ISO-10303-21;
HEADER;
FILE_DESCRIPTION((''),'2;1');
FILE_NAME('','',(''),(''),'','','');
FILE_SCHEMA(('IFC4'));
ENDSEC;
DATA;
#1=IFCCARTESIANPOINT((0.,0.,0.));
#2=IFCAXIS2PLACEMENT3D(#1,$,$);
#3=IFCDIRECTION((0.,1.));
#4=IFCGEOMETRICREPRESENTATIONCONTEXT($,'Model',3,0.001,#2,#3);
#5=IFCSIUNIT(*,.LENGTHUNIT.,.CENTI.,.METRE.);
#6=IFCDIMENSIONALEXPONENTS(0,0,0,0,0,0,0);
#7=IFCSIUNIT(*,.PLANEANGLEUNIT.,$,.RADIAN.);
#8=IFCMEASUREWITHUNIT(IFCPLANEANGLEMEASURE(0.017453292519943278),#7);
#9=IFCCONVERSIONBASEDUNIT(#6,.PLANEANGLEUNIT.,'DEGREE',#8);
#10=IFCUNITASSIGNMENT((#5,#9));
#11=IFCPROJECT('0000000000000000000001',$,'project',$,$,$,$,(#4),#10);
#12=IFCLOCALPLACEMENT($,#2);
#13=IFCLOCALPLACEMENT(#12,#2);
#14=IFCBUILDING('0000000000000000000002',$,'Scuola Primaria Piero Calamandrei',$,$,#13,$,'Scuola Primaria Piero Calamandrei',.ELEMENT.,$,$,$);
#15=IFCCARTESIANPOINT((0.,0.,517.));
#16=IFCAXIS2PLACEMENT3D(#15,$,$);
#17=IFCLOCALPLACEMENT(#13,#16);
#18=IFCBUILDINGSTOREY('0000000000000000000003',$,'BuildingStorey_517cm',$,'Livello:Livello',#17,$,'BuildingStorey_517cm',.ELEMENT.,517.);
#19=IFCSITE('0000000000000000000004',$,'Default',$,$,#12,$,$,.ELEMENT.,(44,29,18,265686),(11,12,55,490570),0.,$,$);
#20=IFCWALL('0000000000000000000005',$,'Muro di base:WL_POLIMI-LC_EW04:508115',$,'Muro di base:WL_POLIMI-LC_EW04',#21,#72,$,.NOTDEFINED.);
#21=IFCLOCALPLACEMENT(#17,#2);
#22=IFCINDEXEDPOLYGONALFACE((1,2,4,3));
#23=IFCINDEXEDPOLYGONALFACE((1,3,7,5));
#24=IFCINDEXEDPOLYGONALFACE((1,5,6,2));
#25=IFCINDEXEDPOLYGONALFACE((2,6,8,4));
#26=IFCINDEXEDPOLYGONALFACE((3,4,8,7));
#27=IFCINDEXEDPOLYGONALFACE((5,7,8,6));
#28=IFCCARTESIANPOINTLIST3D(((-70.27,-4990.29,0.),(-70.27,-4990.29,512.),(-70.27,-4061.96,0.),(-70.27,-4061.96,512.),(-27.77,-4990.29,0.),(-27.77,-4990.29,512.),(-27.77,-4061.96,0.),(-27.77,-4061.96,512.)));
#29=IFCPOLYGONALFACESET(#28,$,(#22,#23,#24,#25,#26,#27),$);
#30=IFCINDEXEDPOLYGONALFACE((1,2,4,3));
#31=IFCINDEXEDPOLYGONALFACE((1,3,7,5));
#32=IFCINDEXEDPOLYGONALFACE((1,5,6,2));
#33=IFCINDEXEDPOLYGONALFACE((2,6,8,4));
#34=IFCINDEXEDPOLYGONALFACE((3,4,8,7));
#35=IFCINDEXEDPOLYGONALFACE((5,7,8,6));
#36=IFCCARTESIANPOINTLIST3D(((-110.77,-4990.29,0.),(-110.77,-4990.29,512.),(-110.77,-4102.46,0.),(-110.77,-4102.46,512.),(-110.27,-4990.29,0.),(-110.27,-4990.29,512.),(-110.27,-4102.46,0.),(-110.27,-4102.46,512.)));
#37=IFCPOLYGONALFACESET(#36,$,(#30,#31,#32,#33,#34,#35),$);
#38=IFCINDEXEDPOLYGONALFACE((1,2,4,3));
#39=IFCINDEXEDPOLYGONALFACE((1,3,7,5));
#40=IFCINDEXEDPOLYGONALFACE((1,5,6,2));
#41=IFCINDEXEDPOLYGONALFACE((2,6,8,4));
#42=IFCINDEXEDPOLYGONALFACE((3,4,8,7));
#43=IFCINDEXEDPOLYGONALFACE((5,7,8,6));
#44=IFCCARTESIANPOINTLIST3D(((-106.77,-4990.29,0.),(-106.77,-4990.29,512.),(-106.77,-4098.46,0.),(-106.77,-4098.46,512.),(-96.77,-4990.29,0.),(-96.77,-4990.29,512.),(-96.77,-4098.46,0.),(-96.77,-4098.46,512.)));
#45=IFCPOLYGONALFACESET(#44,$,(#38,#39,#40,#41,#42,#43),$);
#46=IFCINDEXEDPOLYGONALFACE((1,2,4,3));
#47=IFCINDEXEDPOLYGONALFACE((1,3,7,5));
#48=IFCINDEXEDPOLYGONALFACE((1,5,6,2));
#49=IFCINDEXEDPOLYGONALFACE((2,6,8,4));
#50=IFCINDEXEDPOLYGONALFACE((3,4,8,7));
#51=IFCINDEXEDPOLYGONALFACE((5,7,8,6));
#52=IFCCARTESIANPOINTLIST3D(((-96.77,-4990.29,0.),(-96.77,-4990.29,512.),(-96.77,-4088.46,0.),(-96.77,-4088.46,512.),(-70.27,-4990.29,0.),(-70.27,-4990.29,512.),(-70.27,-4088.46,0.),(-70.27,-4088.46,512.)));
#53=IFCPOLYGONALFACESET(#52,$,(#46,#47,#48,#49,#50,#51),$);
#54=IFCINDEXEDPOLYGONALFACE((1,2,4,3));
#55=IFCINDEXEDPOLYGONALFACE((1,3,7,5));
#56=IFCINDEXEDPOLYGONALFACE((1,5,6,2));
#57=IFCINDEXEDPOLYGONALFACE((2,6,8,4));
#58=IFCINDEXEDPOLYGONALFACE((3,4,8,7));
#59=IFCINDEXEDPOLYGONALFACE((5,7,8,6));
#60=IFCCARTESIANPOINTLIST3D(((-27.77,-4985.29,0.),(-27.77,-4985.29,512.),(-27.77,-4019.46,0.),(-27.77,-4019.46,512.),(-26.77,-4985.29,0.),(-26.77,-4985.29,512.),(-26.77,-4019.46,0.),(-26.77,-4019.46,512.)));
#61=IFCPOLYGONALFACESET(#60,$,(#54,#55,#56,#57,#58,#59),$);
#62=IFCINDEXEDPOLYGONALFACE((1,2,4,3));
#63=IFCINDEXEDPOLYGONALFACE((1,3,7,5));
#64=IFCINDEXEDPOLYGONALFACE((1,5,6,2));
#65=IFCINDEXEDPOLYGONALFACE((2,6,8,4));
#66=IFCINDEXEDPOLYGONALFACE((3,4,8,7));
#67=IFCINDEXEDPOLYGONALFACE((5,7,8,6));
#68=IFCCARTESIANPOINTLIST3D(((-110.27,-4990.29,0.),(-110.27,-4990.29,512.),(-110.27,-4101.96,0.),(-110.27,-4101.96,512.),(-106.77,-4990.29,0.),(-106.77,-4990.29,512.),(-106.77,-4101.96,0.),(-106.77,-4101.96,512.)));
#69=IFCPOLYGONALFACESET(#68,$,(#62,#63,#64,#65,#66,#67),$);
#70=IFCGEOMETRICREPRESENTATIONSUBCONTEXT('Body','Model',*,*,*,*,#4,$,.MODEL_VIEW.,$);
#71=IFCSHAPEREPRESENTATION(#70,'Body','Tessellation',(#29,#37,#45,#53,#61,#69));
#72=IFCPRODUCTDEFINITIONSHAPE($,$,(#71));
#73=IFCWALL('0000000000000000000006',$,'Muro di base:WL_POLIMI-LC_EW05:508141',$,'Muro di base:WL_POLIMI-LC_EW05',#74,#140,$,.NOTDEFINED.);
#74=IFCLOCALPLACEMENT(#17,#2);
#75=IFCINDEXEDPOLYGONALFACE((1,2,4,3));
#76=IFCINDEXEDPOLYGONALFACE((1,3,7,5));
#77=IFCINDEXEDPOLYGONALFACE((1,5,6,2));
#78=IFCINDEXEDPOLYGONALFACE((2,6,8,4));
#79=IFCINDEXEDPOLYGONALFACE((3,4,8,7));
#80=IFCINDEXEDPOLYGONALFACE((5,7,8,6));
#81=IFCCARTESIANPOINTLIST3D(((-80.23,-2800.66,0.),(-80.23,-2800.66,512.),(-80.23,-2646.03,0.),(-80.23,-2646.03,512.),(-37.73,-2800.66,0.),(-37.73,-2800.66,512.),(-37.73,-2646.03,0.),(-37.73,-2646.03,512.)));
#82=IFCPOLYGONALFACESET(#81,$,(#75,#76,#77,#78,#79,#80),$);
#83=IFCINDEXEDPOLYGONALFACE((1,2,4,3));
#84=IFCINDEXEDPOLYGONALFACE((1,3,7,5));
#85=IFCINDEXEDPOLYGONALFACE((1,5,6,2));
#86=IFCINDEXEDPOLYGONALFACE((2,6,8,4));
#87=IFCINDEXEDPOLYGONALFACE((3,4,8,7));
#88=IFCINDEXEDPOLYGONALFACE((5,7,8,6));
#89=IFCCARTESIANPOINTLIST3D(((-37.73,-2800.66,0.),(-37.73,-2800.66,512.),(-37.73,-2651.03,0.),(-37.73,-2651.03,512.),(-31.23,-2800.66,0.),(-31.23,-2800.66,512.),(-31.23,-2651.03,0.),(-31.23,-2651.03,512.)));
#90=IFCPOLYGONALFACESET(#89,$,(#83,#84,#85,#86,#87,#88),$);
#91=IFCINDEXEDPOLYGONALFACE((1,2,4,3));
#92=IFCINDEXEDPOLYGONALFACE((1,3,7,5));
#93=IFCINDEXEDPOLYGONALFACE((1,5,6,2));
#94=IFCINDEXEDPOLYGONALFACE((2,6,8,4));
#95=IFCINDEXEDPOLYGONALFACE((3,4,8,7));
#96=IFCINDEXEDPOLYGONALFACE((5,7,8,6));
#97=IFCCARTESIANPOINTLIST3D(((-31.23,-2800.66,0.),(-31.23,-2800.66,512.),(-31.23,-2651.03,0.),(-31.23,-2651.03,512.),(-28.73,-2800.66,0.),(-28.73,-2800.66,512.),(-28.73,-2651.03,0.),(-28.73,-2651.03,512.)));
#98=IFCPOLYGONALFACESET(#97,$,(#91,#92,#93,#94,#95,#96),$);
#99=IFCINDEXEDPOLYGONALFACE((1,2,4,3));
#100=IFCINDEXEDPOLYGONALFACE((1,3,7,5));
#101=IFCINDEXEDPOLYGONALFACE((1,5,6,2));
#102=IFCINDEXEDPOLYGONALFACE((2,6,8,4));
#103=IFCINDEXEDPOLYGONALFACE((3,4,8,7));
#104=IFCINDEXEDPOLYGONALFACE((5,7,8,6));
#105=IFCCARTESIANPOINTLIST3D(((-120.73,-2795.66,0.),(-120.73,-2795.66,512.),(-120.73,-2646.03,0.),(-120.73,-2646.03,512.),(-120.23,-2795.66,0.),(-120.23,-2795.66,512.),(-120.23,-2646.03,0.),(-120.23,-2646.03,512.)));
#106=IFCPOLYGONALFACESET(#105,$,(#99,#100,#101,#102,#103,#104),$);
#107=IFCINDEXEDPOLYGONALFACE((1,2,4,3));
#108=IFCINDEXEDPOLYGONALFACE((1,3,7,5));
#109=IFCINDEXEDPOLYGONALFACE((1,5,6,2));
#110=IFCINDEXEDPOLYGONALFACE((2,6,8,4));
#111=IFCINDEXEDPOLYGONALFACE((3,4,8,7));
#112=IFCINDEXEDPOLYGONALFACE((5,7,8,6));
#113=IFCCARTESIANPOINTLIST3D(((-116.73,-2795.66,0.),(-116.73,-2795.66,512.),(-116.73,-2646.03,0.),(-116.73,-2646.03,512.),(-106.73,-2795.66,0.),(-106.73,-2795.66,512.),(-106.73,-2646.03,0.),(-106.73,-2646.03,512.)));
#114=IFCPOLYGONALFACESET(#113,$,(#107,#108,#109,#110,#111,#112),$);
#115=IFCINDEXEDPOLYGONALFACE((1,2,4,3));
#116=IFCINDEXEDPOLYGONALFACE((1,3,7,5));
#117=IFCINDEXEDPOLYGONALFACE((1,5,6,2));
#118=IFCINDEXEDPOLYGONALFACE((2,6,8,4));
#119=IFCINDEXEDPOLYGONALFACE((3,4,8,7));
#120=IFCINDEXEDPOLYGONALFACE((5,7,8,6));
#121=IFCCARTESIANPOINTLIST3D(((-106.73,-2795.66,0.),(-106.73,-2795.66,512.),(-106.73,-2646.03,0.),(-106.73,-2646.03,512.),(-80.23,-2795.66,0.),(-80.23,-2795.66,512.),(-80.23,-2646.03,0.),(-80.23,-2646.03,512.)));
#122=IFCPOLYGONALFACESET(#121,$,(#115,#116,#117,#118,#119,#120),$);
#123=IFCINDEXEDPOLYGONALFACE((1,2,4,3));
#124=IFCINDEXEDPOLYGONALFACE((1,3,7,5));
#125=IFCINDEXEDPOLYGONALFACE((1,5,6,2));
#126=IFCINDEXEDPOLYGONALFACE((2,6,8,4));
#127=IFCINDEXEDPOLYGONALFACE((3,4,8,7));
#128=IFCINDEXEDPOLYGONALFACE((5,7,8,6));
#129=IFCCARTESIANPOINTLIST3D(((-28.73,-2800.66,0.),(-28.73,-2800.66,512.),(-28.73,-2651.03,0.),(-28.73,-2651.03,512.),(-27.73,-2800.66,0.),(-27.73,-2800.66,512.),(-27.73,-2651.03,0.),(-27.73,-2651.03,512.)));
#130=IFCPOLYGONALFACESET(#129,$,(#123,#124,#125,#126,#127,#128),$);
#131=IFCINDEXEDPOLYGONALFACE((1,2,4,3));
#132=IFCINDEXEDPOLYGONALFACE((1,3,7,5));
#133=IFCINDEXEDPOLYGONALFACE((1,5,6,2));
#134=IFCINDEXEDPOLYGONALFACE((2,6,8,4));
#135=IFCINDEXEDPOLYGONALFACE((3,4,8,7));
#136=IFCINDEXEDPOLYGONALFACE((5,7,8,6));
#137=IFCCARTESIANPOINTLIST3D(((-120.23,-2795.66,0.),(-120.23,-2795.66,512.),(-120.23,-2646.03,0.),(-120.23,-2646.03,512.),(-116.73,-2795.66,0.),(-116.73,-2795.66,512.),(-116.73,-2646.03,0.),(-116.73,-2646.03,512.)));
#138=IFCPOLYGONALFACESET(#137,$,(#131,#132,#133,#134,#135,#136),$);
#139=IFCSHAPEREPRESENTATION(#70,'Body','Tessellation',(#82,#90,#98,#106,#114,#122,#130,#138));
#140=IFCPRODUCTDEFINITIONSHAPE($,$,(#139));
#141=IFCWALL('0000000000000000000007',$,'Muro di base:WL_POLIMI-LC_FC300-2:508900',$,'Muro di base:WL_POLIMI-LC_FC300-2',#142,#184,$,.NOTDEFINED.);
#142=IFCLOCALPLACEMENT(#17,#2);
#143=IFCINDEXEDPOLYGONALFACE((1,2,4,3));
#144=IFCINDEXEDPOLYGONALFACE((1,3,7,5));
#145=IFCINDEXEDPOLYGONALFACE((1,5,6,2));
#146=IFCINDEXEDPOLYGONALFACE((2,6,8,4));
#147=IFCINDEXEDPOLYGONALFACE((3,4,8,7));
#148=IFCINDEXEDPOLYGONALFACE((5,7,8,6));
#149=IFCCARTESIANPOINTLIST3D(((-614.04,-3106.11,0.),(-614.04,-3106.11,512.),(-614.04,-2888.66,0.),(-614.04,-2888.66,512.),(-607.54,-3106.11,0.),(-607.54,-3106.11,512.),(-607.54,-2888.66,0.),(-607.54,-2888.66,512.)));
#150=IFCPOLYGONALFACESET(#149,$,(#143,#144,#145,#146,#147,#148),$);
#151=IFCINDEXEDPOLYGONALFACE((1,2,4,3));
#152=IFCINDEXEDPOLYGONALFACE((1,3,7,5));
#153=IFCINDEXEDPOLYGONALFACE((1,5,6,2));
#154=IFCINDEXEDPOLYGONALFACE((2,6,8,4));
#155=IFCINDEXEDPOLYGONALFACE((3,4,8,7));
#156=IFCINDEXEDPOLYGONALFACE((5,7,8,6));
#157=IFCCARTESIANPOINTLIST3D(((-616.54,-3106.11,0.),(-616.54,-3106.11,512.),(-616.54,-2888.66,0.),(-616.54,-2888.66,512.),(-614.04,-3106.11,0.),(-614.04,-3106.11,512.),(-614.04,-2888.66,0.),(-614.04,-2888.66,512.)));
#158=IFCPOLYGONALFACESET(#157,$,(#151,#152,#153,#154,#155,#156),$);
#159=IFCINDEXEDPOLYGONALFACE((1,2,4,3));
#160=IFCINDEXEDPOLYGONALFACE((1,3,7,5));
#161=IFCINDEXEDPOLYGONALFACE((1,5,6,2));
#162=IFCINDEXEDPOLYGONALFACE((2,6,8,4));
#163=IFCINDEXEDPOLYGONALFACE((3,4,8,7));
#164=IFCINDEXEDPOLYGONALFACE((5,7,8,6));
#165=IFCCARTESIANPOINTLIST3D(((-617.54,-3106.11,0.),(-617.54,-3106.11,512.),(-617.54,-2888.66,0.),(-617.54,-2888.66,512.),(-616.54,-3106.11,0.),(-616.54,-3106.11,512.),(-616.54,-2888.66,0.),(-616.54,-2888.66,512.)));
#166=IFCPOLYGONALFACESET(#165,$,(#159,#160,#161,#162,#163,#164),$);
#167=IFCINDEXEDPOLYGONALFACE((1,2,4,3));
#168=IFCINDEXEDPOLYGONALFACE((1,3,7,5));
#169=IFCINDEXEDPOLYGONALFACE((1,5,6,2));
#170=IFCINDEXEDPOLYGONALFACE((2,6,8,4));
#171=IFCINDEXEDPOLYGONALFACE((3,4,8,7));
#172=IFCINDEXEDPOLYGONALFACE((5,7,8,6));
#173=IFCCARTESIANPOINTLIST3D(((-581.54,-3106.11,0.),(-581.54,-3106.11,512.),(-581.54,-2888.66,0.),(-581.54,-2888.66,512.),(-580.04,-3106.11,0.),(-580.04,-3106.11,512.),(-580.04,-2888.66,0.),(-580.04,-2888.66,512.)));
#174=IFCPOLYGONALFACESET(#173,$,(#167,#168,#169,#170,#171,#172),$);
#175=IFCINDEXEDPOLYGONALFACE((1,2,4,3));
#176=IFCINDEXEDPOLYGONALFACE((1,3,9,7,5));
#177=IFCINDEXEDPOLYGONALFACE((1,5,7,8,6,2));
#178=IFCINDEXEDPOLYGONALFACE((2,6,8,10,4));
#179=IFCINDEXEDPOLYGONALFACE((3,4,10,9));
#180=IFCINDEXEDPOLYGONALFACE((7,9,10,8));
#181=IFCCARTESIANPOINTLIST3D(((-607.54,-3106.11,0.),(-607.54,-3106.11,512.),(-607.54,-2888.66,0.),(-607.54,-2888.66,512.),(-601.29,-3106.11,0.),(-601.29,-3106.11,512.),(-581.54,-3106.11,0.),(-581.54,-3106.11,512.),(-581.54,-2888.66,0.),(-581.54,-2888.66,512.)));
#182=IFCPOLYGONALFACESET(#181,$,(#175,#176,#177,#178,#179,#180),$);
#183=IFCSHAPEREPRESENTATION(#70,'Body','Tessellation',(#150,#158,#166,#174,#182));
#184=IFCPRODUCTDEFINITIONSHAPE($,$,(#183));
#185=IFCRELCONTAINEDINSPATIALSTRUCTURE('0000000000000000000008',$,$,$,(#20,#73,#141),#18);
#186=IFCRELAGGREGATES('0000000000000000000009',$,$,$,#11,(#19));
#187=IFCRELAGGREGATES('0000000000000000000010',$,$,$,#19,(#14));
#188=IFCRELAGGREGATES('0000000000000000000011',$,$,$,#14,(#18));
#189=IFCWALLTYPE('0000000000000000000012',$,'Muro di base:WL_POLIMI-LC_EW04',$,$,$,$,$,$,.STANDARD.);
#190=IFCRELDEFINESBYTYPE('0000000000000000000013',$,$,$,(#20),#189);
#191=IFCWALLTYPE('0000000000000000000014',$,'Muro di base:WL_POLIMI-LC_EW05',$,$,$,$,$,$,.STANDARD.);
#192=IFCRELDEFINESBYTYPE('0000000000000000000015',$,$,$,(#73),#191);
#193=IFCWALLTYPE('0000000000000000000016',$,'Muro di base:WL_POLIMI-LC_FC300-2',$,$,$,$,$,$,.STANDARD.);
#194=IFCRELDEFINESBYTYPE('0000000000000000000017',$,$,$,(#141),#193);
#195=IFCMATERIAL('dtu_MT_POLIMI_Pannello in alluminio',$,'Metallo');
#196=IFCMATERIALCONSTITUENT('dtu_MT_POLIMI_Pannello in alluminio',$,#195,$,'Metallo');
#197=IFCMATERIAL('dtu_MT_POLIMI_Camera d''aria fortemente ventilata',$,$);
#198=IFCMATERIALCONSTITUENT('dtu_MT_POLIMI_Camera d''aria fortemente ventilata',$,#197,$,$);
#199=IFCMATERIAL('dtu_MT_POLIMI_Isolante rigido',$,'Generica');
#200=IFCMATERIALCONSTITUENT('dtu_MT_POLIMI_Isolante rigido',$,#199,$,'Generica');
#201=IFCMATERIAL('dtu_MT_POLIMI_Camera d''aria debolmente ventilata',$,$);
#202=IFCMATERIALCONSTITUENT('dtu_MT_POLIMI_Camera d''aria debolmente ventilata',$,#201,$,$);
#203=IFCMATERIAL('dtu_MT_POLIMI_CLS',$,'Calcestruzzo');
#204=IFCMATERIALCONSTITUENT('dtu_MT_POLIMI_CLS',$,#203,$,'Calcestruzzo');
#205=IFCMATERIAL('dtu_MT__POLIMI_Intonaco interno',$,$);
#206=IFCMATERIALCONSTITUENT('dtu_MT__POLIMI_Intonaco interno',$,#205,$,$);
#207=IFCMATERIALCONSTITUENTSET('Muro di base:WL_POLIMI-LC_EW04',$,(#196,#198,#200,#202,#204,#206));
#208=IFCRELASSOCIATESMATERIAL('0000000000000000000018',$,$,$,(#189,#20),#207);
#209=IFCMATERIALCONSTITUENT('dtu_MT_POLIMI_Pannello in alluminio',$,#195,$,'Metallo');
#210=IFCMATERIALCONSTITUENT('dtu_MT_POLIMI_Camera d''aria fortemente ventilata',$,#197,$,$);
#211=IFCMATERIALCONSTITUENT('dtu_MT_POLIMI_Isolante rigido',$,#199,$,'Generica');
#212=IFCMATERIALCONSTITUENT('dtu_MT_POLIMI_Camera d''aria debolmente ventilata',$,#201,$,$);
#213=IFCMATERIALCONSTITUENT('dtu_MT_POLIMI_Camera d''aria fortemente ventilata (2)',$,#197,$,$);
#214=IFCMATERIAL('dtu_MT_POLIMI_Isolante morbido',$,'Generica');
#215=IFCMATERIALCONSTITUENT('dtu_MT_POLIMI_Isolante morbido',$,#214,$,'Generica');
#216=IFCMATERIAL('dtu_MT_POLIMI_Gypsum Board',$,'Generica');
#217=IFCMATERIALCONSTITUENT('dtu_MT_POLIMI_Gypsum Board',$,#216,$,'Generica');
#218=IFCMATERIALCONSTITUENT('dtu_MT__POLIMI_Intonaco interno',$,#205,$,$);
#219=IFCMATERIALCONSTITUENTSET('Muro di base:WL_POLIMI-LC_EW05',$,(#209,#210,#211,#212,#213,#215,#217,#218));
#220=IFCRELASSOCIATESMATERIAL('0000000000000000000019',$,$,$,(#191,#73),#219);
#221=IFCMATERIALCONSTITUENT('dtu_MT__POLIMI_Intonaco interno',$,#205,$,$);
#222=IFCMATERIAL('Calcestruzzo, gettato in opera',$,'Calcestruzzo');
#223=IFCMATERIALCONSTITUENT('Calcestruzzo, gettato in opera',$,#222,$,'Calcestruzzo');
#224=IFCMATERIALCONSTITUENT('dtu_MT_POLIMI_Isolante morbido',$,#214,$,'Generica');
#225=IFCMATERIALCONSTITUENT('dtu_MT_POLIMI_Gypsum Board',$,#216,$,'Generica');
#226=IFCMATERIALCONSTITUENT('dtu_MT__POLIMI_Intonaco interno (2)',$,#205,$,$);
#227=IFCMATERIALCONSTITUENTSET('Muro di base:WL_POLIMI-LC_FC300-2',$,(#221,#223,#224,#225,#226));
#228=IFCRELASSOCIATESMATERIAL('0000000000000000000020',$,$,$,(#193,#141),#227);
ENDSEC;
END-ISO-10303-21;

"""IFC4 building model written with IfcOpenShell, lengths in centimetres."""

from ifc_helpers import new_model, entity, si_unit, converted_unit, direction, frame, origin, place, context, subcontext, project, spatial, indexed_curve, outline, extrude, material, constituent, constituent_set, type_object, element, save


model = new_model("IFC4")

# Units and contexts
model_context = context("Model", 3, precision=0.001, world=origin(), true_north=direction((0.0, 1.0)))
body_context = subcontext(model_context, "Body", "Model", "MODEL_VIEW")
ifc_project = project(units=[si_unit("LENGTHUNIT", "METRE", prefix="CENTI"), converted_unit("PLANEANGLEUNIT", "DEGREE", entity("IfcPlaneAngleMeasure", 0.017453292519943278), si_unit("PLANEANGLEUNIT", "RADIAN"), dimensions=[0, 0, 0, 0, 0, 0, 0])], contexts=[model_context])

# Site, building, storey
site_placement = place(None, origin())
site = spatial("IfcSite", under=ifc_project, at=site_placement, Name="Default", CompositionType="ELEMENT", RefLatitude=(44, 29, 18, 265686), RefLongitude=(11, 12, 55, 490570), RefElevation=0.0)
building_placement = place(site_placement, origin())
building = spatial("IfcBuilding", under=site, at=building_placement, Name="Scuola Primaria Piero Calamandrei", LongName="Scuola Primaria Piero Calamandrei", CompositionType="ELEMENT")
storey_placement = place(building_placement, frame((0.0, 0.0, 517.0)))
storey = spatial("IfcBuildingStorey", under=building, at=storey_placement, Name="BuildingStorey_517cm", ObjectType="Livello:Livello", LongName="BuildingStorey_517cm", CompositionType="ELEMENT", Elevation=517.0)

# Walls
ifc_material_1 = material(Name="dtu_MT_POLIMI_Pannello in alluminio", Category="Metallo")
ifc_constituent_1 = constituent(ifc_material_1, Name="dtu_MT_POLIMI_Pannello in alluminio", Category="Metallo")
ifc_material_2 = material(Name="dtu_MT_POLIMI_Camera d'aria fortemente ventilata")
ifc_constituent_2 = constituent(ifc_material_2, Name="dtu_MT_POLIMI_Camera d'aria fortemente ventilata")
ifc_material_3 = material(Name="dtu_MT_POLIMI_Isolante rigido", Category="Generica")
ifc_constituent_3 = constituent(ifc_material_3, Name="dtu_MT_POLIMI_Isolante rigido", Category="Generica")
ifc_material_4 = material(Name="dtu_MT_POLIMI_Camera d'aria debolmente ventilata")
ifc_constituent_4 = constituent(ifc_material_4, Name="dtu_MT_POLIMI_Camera d'aria debolmente ventilata")
ifc_material_5 = material(Name="dtu_MT_POLIMI_CLS", Category="Calcestruzzo")
ifc_constituent_5 = constituent(ifc_material_5, Name="dtu_MT_POLIMI_CLS", Category="Calcestruzzo")
ifc_material_6 = material(Name="dtu_MT__POLIMI_Intonaco interno")
ifc_constituent_6 = constituent(ifc_material_6, Name="dtu_MT__POLIMI_Intonaco interno")
ifc_constituent_set_1 = constituent_set(constituents=[ifc_constituent_1, ifc_constituent_2, ifc_constituent_3, ifc_constituent_4, ifc_constituent_5, ifc_constituent_6], Name="Muro di base:WL_POLIMI-LC_EW04")
wall_type_1 = type_object("IfcWallType", Name="Muro di base:WL_POLIMI-LC_EW04", PredefinedType="STANDARD", material=ifc_constituent_set_1)
wall_1_placement = place(storey_placement, frame((-68.77, -4990.29, 0.0), z_axis=(0.0, 0.0, 1.0), x_axis=(0.0, 1.0, 0.0)))
element("IfcWall", 1, at=wall_1_placement, inside=storey, type_object=wall_type_1, material=ifc_constituent_set_1, Name="Muro di base:WL_POLIMI-LC_EW04:508115", ObjectType="Muro di base:WL_POLIMI-LC_EW04", PredefinedType="NOTDEFINED", context=body_context, shape_type="SweptSolid", body=[
    extrude(outline(indexed_curve([(-464.16, -21.25), (464.16, -21.25), (464.16, 21.25), (-464.16, 21.25), (-464.16, -21.25)], self_intersect=False)), frame((464.16, -19.75, 0.0)), (0.0, 0.0, 1.0), 512.0),
    extrude(outline(indexed_curve([(-0.25, -443.91), (0.25, -443.91), (0.25, 443.91), (-0.25, 443.91), (-0.25, -443.91)], self_intersect=False)), frame((443.91, 41.75, 0.0), z_axis=(0.0, 0.0, 1.0), x_axis=(0.0, -1.0, 0.0)), (0.0, 0.0, 1.0), 512.0),
    extrude(outline(indexed_curve([(-445.91, -5.0), (445.91, -5.0), (445.91, 5.0), (-445.91, 5.0), (-445.91, -5.0)], self_intersect=False)), frame((445.91, 33.0, 0.0)), (0.0, 0.0, 1.0), 512.0),
    extrude(outline(indexed_curve([(-450.91, -13.25), (450.91, -13.25), (450.91, 13.25), (-450.91, 13.25), (-450.91, -13.25)], self_intersect=False)), frame((450.91, 14.75, 0.0)), (0.0, 0.0, 1.0), 512.0),
    extrude(outline(indexed_curve([(-482.91, -0.5), (482.91, -0.5), (482.91, 0.5), (-482.91, 0.5), (-482.91, -0.5)], self_intersect=False)), frame((487.91, -41.5, 0.0)), (0.0, 0.0, 1.0), 512.0),
    extrude(outline(indexed_curve([(-444.16, -1.75), (444.16, -1.75), (444.16, 1.75), (-444.16, 1.75), (-444.16, -1.75)], self_intersect=False)), frame((444.16, 39.75, 0.0)), (0.0, 0.0, 1.0), 512.0),
])
ifc_constituent_7 = constituent(ifc_material_1, Name="dtu_MT_POLIMI_Pannello in alluminio", Category="Metallo")
ifc_constituent_8 = constituent(ifc_material_2, Name="dtu_MT_POLIMI_Camera d'aria fortemente ventilata")
ifc_constituent_9 = constituent(ifc_material_3, Name="dtu_MT_POLIMI_Isolante rigido", Category="Generica")
ifc_constituent_10 = constituent(ifc_material_4, Name="dtu_MT_POLIMI_Camera d'aria debolmente ventilata")
ifc_constituent_11 = constituent(ifc_material_2, Name="dtu_MT_POLIMI_Camera d'aria fortemente ventilata (2)")
ifc_material_7 = material(Name="dtu_MT_POLIMI_Isolante morbido", Category="Generica")
ifc_constituent_12 = constituent(ifc_material_7, Name="dtu_MT_POLIMI_Isolante morbido", Category="Generica")
ifc_material_8 = material(Name="dtu_MT_POLIMI_Gypsum Board", Category="Generica")
ifc_constituent_13 = constituent(ifc_material_8, Name="dtu_MT_POLIMI_Gypsum Board", Category="Generica")
ifc_constituent_14 = constituent(ifc_material_6, Name="dtu_MT__POLIMI_Intonaco interno")
ifc_constituent_set_2 = constituent_set(constituents=[ifc_constituent_7, ifc_constituent_8, ifc_constituent_9, ifc_constituent_10, ifc_constituent_11, ifc_constituent_12, ifc_constituent_13, ifc_constituent_14], Name="Muro di base:WL_POLIMI-LC_EW05")
wall_type_2 = type_object("IfcWallType", Name="Muro di base:WL_POLIMI-LC_EW05", PredefinedType="STANDARD", material=ifc_constituent_set_2)
wall_2_placement = place(storey_placement, frame((-74.23, -2800.66, 0.0), z_axis=(0.0, 0.0, 1.0), x_axis=(0.0, 1.0, 0.0)))
element("IfcWall", 2, at=wall_2_placement, inside=storey, type_object=wall_type_2, material=ifc_constituent_set_2, Name="Muro di base:WL_POLIMI-LC_EW05:508141", ObjectType="Muro di base:WL_POLIMI-LC_EW05", PredefinedType="NOTDEFINED", context=body_context, shape_type="SweptSolid", body=[
    extrude(outline(indexed_curve([(-77.32, -21.25), (77.32, -21.25), (77.32, 21.25), (-77.32, 21.25), (-77.32, -21.25)], self_intersect=False)), frame((77.32, -15.25, 0.0)), (0.0, 0.0, 1.0), 512.0),
    extrude(outline(indexed_curve([(-74.82, -3.25), (74.82, -3.25), (74.82, 3.25), (-74.82, 3.25), (-74.82, -3.25)], self_intersect=False)), frame((74.82, -39.75, 0.0)), (0.0, 0.0, 1.0), 512.0),
    extrude(outline(indexed_curve([(-74.82, -1.25), (74.82, -1.25), (74.82, 1.25), (-74.82, 1.25), (-74.82, -1.25)], self_intersect=False)), frame((74.82, -44.25, 0.0)), (0.0, 0.0, 1.0), 512.0),
    extrude(outline(indexed_curve([(-0.25, -74.82), (0.25, -74.82), (0.25, 74.82), (-0.25, 74.82), (-0.25, -74.82)], self_intersect=False)), frame((79.82, 46.25, 0.0), z_axis=(0.0, 0.0, 1.0), x_axis=(0.0, -1.0, 0.0)), (0.0, 0.0, 1.0), 512.0),
    extrude(outline(indexed_curve([(-74.82, -5.0), (74.82, -5.0), (74.82, 5.0), (-74.82, 5.0), (-74.82, -5.0)], self_intersect=False)), frame((79.82, 37.5, 0.0)), (0.0, 0.0, 1.0), 512.0),
    extrude(outline(indexed_curve([(-74.82, -13.25), (74.82, -13.25), (74.82, 13.25), (-74.82, 13.25), (-74.82, -13.25)], self_intersect=False)), frame((79.82, 19.25, 0.0)), (0.0, 0.0, 1.0), 512.0),
    extrude(outline(indexed_curve([(-0.5, -74.82), (0.5, -74.82), (0.5, 74.82), (-0.5, 74.82), (-0.5, -74.82)], self_intersect=False)), frame((74.82, -46.0, 0.0), z_axis=(0.0, 0.0, 1.0), x_axis=(0.0, 1.0, 0.0)), (0.0, 0.0, 1.0), 512.0),
    extrude(outline(indexed_curve([(-74.82, -1.75), (74.82, -1.75), (74.82, 1.75), (-74.82, 1.75), (-74.82, -1.75)], self_intersect=False)), frame((79.82, 44.25, 0.0)), (0.0, 0.0, 1.0), 512.0),
])

# Shared definitions
ifc_constituent_15 = constituent(ifc_material_6, Name="dtu_MT__POLIMI_Intonaco interno")
ifc_material_9 = material(Name="Calcestruzzo, gettato in opera", Category="Calcestruzzo")
ifc_constituent_16 = constituent(ifc_material_9, Name="Calcestruzzo, gettato in opera", Category="Calcestruzzo")
ifc_constituent_17 = constituent(ifc_material_7, Name="dtu_MT_POLIMI_Isolante morbido", Category="Generica")
ifc_constituent_18 = constituent(ifc_material_8, Name="dtu_MT_POLIMI_Gypsum Board", Category="Generica")
ifc_constituent_19 = constituent(ifc_material_6, Name="dtu_MT__POLIMI_Intonaco interno (2)")
ifc_constituent_set_3 = constituent_set(constituents=[ifc_constituent_15, ifc_constituent_16, ifc_constituent_17, ifc_constituent_18, ifc_constituent_19], Name="Muro di base:WL_POLIMI-LC_FC300-2")
wall_type_3 = type_object("IfcWallType", Name="Muro di base:WL_POLIMI-LC_FC300-2", PredefinedType="STANDARD", material=ifc_constituent_set_3)

# Wall
wall_3_placement = place(storey_placement, frame((-598.79, -2888.66, 0.0), z_axis=(0.0, 0.0, 1.0), x_axis=(0.0, -1.0, 0.0)))
element("IfcWall", 3, at=wall_3_placement, inside=storey, type_object=wall_type_3, material=ifc_constituent_set_3, Name="Muro di base:WL_POLIMI-LC_FC300-2:508900", ObjectType="Muro di base:WL_POLIMI-LC_FC300-2", PredefinedType="NOTDEFINED", context=body_context, shape_type="SweptSolid", body=[
    extrude(outline(indexed_curve([(-108.72, -3.25), (108.72, -3.25), (108.72, 3.25), (-108.72, 3.25), (-108.72, -3.25)], self_intersect=False)), frame((108.72, -12.0, 0.0)), (0.0, 0.0, 1.0), 512.0),
    extrude(outline(indexed_curve([(-108.72, -1.25), (108.72, -1.25), (108.72, 1.25), (-108.72, 1.25), (-108.72, -1.25)], self_intersect=False)), frame((108.72, -16.5, 0.0)), (0.0, 0.0, 1.0), 512.0),
    extrude(outline(indexed_curve([(-0.5, -108.72), (0.5, -108.72), (0.5, 108.72), (-0.5, 108.72), (-0.5, -108.72)], self_intersect=False)), frame((108.72, -18.25, 0.0), z_axis=(0.0, 0.0, 1.0), x_axis=(0.0, 1.0, 0.0)), (0.0, 0.0, 1.0), 512.0),
    extrude(outline(indexed_curve([(-0.75, -108.72), (0.75, -108.72), (0.75, 108.72), (-0.75, 108.72), (-0.75, -108.72)], self_intersect=False)), frame((108.72, 18.0, 0.0), z_axis=(0.0, 0.0, 1.0), x_axis=(0.0, -1.0, 0.0)), (0.0, 0.0, 1.0), 512.0),
    extrude(outline(indexed_curve([(-130.47, -11.65), (86.98, -11.65), (86.98, -5.4), (86.98, 14.35), (-130.47, 14.35), (-130.47, -11.65)], self_intersect=False)), frame((130.47, 2.9, 0.0)), (0.0, 0.0, 1.0), 512.0),
])

save(model, "model.ifc")
